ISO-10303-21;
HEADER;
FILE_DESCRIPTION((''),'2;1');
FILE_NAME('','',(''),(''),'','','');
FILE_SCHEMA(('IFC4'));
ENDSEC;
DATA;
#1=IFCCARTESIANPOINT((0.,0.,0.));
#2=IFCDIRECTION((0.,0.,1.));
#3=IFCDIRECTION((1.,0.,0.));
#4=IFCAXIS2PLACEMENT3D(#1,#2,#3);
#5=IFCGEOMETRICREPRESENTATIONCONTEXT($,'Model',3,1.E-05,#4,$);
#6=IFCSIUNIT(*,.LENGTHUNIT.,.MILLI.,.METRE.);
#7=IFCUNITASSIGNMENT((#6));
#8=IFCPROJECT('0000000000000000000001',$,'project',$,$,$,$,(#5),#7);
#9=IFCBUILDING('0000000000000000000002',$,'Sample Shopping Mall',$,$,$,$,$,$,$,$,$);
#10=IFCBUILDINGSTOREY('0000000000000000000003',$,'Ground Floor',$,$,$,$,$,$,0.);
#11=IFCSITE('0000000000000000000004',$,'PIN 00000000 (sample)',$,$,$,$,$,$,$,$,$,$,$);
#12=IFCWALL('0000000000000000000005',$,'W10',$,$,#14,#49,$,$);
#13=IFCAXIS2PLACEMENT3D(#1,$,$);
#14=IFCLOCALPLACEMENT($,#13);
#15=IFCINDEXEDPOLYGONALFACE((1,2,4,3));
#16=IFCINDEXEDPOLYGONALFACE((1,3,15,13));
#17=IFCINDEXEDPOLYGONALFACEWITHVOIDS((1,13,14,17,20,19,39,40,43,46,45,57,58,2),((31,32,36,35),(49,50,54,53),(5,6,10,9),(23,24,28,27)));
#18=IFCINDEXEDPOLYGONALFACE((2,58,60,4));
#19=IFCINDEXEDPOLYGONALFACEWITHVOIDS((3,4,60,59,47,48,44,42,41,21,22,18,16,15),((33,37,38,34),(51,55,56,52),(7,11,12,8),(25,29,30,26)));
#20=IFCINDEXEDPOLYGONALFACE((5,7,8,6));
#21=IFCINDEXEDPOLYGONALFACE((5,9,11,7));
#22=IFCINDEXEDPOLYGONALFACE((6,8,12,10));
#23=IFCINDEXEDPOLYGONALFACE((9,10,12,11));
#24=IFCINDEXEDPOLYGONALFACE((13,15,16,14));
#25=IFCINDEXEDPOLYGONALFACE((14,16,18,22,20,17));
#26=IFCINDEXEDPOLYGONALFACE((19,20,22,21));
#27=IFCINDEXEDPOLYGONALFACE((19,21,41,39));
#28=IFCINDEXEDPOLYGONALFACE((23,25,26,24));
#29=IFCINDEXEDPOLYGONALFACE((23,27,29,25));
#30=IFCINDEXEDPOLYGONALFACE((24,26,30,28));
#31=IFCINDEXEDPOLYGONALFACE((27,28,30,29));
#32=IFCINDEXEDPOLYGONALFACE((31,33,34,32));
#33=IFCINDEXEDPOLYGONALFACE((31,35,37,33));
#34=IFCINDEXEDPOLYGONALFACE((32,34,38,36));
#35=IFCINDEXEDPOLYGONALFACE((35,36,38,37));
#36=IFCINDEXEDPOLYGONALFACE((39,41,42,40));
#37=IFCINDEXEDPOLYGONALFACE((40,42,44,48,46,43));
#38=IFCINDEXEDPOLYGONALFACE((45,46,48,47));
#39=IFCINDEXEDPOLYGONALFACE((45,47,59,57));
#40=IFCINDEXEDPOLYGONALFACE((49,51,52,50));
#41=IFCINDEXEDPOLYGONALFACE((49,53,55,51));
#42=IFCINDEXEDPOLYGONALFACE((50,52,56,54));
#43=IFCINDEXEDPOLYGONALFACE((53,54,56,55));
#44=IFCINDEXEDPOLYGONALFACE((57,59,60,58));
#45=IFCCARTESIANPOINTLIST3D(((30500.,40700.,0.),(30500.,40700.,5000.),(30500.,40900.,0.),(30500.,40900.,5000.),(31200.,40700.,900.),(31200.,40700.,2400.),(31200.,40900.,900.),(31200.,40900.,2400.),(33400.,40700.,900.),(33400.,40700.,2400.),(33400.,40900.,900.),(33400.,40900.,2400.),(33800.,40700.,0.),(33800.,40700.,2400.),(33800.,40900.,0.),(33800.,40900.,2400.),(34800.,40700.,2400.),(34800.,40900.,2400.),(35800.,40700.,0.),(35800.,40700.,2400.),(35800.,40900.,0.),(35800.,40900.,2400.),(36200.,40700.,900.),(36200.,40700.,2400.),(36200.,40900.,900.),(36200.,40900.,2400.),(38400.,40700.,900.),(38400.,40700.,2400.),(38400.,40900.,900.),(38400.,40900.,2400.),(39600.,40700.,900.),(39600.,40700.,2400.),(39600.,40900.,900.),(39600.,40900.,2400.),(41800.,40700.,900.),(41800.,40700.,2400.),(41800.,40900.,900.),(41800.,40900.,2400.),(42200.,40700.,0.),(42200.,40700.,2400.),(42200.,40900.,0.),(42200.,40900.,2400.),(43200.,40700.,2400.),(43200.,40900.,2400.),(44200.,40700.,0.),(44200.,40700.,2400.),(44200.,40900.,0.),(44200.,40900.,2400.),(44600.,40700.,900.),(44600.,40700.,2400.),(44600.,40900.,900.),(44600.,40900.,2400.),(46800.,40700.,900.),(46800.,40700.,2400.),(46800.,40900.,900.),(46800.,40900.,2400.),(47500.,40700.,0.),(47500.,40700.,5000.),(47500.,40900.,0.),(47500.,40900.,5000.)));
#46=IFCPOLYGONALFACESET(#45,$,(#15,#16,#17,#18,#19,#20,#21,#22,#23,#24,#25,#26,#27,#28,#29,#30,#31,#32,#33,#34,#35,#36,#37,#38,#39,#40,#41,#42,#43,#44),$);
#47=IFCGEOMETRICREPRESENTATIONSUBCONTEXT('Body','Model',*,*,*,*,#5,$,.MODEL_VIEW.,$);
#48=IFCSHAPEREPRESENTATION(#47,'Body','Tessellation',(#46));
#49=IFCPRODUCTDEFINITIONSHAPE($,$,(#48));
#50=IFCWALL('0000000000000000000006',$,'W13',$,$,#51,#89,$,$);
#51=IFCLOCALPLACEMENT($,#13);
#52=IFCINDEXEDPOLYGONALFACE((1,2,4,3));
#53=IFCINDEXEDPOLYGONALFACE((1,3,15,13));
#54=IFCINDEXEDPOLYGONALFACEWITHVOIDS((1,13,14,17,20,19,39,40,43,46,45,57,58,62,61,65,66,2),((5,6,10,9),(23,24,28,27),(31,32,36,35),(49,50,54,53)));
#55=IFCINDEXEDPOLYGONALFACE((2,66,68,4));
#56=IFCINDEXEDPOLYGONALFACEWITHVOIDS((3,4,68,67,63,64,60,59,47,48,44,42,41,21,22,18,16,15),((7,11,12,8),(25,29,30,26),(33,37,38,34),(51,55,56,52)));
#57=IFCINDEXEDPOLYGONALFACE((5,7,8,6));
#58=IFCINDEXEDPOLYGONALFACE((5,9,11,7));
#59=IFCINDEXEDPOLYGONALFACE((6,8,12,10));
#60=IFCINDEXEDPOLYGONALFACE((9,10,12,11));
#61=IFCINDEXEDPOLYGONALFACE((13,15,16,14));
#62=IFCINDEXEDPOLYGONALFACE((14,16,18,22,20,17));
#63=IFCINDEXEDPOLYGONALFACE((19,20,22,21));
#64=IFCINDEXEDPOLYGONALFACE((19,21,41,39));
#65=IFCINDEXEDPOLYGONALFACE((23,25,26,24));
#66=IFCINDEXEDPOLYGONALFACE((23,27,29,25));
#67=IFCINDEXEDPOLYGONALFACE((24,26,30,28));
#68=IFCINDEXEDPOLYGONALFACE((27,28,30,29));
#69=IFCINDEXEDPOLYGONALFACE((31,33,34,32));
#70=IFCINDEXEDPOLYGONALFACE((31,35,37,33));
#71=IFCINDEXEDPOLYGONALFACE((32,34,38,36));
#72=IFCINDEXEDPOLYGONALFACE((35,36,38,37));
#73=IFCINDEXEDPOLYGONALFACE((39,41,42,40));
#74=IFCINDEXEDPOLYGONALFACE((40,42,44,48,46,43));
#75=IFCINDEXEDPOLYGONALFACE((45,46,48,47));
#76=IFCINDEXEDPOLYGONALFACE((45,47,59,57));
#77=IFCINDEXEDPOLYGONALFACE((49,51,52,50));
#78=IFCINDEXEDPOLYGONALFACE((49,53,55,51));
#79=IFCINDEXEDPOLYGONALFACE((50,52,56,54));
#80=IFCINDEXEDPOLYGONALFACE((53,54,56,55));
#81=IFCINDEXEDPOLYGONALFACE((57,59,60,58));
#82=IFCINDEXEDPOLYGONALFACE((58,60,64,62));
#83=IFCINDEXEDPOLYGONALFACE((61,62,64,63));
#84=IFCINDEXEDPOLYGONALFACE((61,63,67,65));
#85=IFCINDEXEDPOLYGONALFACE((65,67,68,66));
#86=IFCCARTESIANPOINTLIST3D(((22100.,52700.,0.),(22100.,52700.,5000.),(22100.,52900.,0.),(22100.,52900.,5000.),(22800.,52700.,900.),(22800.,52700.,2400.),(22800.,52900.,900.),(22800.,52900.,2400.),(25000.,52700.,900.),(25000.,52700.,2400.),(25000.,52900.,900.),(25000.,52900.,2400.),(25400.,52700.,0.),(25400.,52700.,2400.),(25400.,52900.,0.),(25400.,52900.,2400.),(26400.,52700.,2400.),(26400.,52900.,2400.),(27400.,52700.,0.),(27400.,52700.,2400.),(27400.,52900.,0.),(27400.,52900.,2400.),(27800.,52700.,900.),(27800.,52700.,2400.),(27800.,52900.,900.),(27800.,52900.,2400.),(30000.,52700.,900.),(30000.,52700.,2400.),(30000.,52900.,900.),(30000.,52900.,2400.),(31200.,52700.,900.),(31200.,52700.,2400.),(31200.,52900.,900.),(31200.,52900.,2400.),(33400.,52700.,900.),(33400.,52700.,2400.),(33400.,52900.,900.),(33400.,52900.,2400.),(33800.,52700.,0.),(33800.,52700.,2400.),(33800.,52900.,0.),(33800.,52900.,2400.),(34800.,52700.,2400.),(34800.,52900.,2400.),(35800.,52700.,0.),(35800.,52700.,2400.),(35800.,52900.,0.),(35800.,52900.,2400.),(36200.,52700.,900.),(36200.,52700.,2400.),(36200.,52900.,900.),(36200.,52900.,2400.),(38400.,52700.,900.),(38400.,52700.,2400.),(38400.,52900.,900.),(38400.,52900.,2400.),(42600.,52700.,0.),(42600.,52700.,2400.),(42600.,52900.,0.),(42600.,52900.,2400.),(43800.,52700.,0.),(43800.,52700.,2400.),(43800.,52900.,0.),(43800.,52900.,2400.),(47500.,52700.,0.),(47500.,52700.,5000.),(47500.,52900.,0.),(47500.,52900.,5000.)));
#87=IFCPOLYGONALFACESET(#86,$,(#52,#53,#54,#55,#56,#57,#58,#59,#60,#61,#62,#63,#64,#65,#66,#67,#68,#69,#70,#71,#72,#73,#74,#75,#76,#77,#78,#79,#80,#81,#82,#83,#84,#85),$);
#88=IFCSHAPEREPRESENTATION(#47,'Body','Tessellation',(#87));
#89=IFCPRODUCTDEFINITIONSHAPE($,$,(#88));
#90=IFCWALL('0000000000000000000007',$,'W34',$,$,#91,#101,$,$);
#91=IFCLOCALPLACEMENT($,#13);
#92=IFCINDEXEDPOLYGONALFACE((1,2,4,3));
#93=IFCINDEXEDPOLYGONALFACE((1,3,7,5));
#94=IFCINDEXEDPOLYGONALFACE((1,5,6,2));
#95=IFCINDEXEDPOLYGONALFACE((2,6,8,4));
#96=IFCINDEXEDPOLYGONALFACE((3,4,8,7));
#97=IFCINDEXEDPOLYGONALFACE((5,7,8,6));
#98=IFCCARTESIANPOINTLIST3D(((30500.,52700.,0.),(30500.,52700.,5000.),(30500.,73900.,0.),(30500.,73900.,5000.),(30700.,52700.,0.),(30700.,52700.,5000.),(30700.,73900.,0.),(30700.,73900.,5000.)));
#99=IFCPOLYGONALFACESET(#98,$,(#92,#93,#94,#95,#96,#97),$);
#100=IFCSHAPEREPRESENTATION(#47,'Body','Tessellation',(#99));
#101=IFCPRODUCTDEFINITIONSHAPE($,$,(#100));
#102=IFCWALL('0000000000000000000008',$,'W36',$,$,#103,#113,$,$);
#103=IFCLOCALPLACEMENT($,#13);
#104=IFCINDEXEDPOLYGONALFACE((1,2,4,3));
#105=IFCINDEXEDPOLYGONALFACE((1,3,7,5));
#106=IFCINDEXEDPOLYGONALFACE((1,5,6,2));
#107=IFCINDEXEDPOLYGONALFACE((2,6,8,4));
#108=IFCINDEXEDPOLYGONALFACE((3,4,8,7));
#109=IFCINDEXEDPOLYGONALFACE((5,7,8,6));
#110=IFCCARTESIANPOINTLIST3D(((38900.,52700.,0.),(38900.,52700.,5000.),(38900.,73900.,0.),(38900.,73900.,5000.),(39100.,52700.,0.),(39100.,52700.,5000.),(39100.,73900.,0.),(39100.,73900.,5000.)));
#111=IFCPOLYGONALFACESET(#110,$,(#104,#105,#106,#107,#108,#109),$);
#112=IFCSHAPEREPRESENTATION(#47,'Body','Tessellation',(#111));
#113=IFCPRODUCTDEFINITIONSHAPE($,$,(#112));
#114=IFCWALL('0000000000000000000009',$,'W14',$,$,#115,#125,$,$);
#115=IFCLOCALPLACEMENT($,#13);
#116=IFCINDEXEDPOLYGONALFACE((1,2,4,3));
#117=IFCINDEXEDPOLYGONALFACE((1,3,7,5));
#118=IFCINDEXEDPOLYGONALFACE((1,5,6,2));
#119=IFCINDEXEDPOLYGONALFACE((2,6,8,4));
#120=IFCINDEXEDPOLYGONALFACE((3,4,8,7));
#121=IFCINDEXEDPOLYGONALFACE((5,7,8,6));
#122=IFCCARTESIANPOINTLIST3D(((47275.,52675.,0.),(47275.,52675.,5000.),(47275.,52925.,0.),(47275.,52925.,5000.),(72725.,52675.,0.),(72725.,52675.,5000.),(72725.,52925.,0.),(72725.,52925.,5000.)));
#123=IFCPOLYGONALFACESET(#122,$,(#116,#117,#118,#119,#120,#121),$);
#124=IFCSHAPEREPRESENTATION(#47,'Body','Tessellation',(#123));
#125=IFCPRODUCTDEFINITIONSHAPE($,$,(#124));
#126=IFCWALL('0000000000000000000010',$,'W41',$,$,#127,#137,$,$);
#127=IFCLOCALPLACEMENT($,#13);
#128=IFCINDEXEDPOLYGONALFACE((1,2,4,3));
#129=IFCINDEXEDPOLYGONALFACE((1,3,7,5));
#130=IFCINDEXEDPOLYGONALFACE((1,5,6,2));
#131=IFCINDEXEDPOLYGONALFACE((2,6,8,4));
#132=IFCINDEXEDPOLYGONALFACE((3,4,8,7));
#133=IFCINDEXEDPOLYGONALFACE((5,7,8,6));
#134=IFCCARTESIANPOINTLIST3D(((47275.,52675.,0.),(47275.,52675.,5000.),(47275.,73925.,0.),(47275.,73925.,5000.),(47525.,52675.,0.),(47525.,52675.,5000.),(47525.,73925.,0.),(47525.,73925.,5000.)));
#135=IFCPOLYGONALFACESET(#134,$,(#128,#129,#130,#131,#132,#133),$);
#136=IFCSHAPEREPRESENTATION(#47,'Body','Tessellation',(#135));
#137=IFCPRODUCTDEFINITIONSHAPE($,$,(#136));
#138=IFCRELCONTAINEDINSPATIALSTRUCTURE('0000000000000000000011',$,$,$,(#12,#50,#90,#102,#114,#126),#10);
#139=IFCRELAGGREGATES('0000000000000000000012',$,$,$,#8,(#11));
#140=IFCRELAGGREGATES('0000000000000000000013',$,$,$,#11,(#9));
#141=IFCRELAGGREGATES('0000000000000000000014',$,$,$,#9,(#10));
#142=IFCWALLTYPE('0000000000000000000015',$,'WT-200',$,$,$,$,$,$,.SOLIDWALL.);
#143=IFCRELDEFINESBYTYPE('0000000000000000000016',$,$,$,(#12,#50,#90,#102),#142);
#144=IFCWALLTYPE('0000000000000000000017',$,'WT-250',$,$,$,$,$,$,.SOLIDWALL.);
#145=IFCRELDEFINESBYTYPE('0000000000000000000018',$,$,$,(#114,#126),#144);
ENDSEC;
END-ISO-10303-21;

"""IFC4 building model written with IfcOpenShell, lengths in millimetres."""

from ifc_helpers import new_model, si_unit, frame, origin_with_axes, place, context, subcontext, project, spatial, indexed_curve, outline, extrude, type_object, element, save


model = new_model("IFC4")

# Units and contexts
model_context = context("Model", 3, precision=1e-05, world=origin_with_axes())
body_context = subcontext(model_context, "Body", "Model", "MODEL_VIEW")
ifc_project = project(units=[si_unit("LENGTHUNIT", "METRE", prefix="MILLI")], contexts=[model_context])

# Site, building, storey
site = spatial("IfcSite", under=ifc_project, Name="PIN 00000000 (sample)")
building = spatial("IfcBuilding", under=site, Name="Sample Shopping Mall")
storey = spatial("IfcBuildingStorey", under=building, Name="Ground Floor", Elevation=0.0)

# Walls, openings
wall_type_1 = type_object("IfcWallType", Name="WT-200", PredefinedType="SOLIDWALL")
wall_1_placement = place(None, frame((30500.0, 40700.0, 0.0), z_axis=(0.0, 0.0, 1.0), x_axis=(1.0, 0.0, 0.0)))
wall_1 = element("IfcWall", 1, at=wall_1_placement, inside=storey, type_object=wall_type_1, Name="W10", context=body_context, shape_type="SweptSolid", body=[
    extrude(outline(indexed_curve([(0.0, 0.0), (0.0, 200.0), (17000.0, 200.0), (17000.0, 0.0), (0.0, 0.0)], self_intersect=False)), origin_with_axes(), (0.0, 0.0, 1.0), 5000.0),
])
opening_1_placement = place(wall_1_placement, frame((3300.0, -100.0, 0.0), z_axis=(0.0, 0.0, 1.0), x_axis=(1.0, 0.0, 0.0)))
element("IfcOpeningElement", 2, at=opening_1_placement, cuts=wall_1, context=body_context, shape_type="SweptSolid", body=[
    extrude(outline(indexed_curve([(0.0, 0.0), (0.0, 400.0), (1000.0, 400.0), (1000.0, 0.0), (0.0, 0.0)], self_intersect=False)), origin_with_axes(), (0.0, 0.0, 1.0), 2400.0),
])
opening_2_placement = place(wall_1_placement, frame((4300.0, -100.0, 0.0), z_axis=(0.0, 0.0, 1.0), x_axis=(1.0, 0.0, 0.0)))
element("IfcOpeningElement", 3, at=opening_2_placement, cuts=wall_1, context=body_context, shape_type="SweptSolid", body=[
    extrude(outline(indexed_curve([(0.0, 0.0), (0.0, 400.0), (1000.0, 400.0), (1000.0, 0.0), (0.0, 0.0)], self_intersect=False)), origin_with_axes(), (0.0, 0.0, 1.0), 2400.0),
])
opening_3_placement = place(wall_1_placement, frame((11700.0, -100.0, 0.0), z_axis=(0.0, 0.0, 1.0), x_axis=(1.0, 0.0, 0.0)))
element("IfcOpeningElement", 4, at=opening_3_placement, cuts=wall_1, context=body_context, shape_type="SweptSolid", body=[
    extrude(outline(indexed_curve([(0.0, 0.0), (0.0, 400.0), (1000.0, 400.0), (1000.0, 0.0), (0.0, 0.0)], self_intersect=False)), origin_with_axes(), (0.0, 0.0, 1.0), 2400.0),
])
opening_4_placement = place(wall_1_placement, frame((12700.0, -100.0, 0.0), z_axis=(0.0, 0.0, 1.0), x_axis=(1.0, 0.0, 0.0)))
element("IfcOpeningElement", 5, at=opening_4_placement, cuts=wall_1, context=body_context, shape_type="SweptSolid", body=[
    extrude(outline(indexed_curve([(0.0, 0.0), (0.0, 400.0), (1000.0, 400.0), (1000.0, 0.0), (0.0, 0.0)], self_intersect=False)), origin_with_axes(), (0.0, 0.0, 1.0), 2400.0),
])
opening_5_placement = place(wall_1_placement, frame((700.0, -100.0, 900.0), z_axis=(0.0, 0.0, 1.0), x_axis=(1.0, 0.0, 0.0)))
element("IfcOpeningElement", 6, at=opening_5_placement, cuts=wall_1, context=body_context, shape_type="SweptSolid", body=[
    extrude(outline(indexed_curve([(0.0, 0.0), (0.0, 400.0), (2200.0, 400.0), (2200.0, 0.0), (0.0, 0.0)], self_intersect=False)), origin_with_axes(), (0.0, 0.0, 1.0), 1500.0),
])
opening_6_placement = place(wall_1_placement, frame((5700.0, -100.0, 900.0), z_axis=(0.0, 0.0, 1.0), x_axis=(1.0, 0.0, 0.0)))
element("IfcOpeningElement", 7, at=opening_6_placement, cuts=wall_1, context=body_context, shape_type="SweptSolid", body=[
    extrude(outline(indexed_curve([(0.0, 0.0), (0.0, 400.0), (2200.0, 400.0), (2200.0, 0.0), (0.0, 0.0)], self_intersect=False)), origin_with_axes(), (0.0, 0.0, 1.0), 1500.0),
])
opening_7_placement = place(wall_1_placement, frame((9100.0, -100.0, 900.0), z_axis=(0.0, 0.0, 1.0), x_axis=(1.0, 0.0, 0.0)))
element("IfcOpeningElement", 8, at=opening_7_placement, cuts=wall_1, context=body_context, shape_type="SweptSolid", body=[
    extrude(outline(indexed_curve([(0.0, 0.0), (0.0, 400.0), (2200.0, 400.0), (2200.0, 0.0), (0.0, 0.0)], self_intersect=False)), origin_with_axes(), (0.0, 0.0, 1.0), 1500.0),
])
opening_8_placement = place(wall_1_placement, frame((14100.0, -100.0, 900.0), z_axis=(0.0, 0.0, 1.0), x_axis=(1.0, 0.0, 0.0)))
element("IfcOpeningElement", 9, at=opening_8_placement, cuts=wall_1, context=body_context, shape_type="SweptSolid", body=[
    extrude(outline(indexed_curve([(0.0, 0.0), (0.0, 400.0), (2200.0, 400.0), (2200.0, 0.0), (0.0, 0.0)], self_intersect=False)), origin_with_axes(), (0.0, 0.0, 1.0), 1500.0),
])
wall_2_placement = place(None, frame((22100.0, 52700.0, 0.0), z_axis=(0.0, 0.0, 1.0), x_axis=(1.0, 0.0, 0.0)))
wall_2 = element("IfcWall", 10, at=wall_2_placement, inside=storey, type_object=wall_type_1, Name="W13", context=body_context, shape_type="SweptSolid", body=[
    extrude(outline(indexed_curve([(0.0, 0.0), (0.0, 200.0), (25400.0, 200.0), (25400.0, 0.0), (0.0, 0.0)], self_intersect=False)), origin_with_axes(), (0.0, 0.0, 1.0), 5000.0),
])
opening_9_placement = place(wall_2_placement, frame((3300.0, -100.0, 0.0), z_axis=(0.0, 0.0, 1.0), x_axis=(1.0, 0.0, 0.0)))
element("IfcOpeningElement", 11, at=opening_9_placement, cuts=wall_2, context=body_context, shape_type="SweptSolid", body=[
    extrude(outline(indexed_curve([(0.0, 0.0), (0.0, 400.0), (1000.0, 400.0), (1000.0, 0.0), (0.0, 0.0)], self_intersect=False)), origin_with_axes(), (0.0, 0.0, 1.0), 2400.0),
])
opening_10_placement = place(wall_2_placement, frame((4300.0, -100.0, 0.0), z_axis=(0.0, 0.0, 1.0), x_axis=(1.0, 0.0, 0.0)))
element("IfcOpeningElement", 12, at=opening_10_placement, cuts=wall_2, context=body_context, shape_type="SweptSolid", body=[
    extrude(outline(indexed_curve([(0.0, 0.0), (0.0, 400.0), (1000.0, 400.0), (1000.0, 0.0), (0.0, 0.0)], self_intersect=False)), origin_with_axes(), (0.0, 0.0, 1.0), 2400.0),
])
opening_11_placement = place(wall_2_placement, frame((11700.0, -100.0, 0.0), z_axis=(0.0, 0.0, 1.0), x_axis=(1.0, 0.0, 0.0)))
element("IfcOpeningElement", 13, at=opening_11_placement, cuts=wall_2, context=body_context, shape_type="SweptSolid", body=[
    extrude(outline(indexed_curve([(0.0, 0.0), (0.0, 400.0), (1000.0, 400.0), (1000.0, 0.0), (0.0, 0.0)], self_intersect=False)), origin_with_axes(), (0.0, 0.0, 1.0), 2400.0),
])
opening_12_placement = place(wall_2_placement, frame((12700.0, -100.0, 0.0), z_axis=(0.0, 0.0, 1.0), x_axis=(1.0, 0.0, 0.0)))
element("IfcOpeningElement", 14, at=opening_12_placement, cuts=wall_2, context=body_context, shape_type="SweptSolid", body=[
    extrude(outline(indexed_curve([(0.0, 0.0), (0.0, 400.0), (1000.0, 400.0), (1000.0, 0.0), (0.0, 0.0)], self_intersect=False)), origin_with_axes(), (0.0, 0.0, 1.0), 2400.0),
])
opening_13_placement = place(wall_2_placement, frame((20500.0, -100.0, 0.0), z_axis=(0.0, 0.0, 1.0), x_axis=(1.0, 0.0, 0.0)))
element("IfcOpeningElement", 15, at=opening_13_placement, cuts=wall_2, context=body_context, shape_type="SweptSolid", body=[
    extrude(outline(indexed_curve([(0.0, 0.0), (0.0, 400.0), (1200.0, 400.0), (1200.0, 0.0), (0.0, 0.0)], self_intersect=False)), origin_with_axes(), (0.0, 0.0, 1.0), 2400.0),
])
opening_14_placement = place(wall_2_placement, frame((700.0, -100.0, 900.0), z_axis=(0.0, 0.0, 1.0), x_axis=(1.0, 0.0, 0.0)))
element("IfcOpeningElement", 16, at=opening_14_placement, cuts=wall_2, context=body_context, shape_type="SweptSolid", body=[
    extrude(outline(indexed_curve([(0.0, 0.0), (0.0, 400.0), (2200.0, 400.0), (2200.0, 0.0), (0.0, 0.0)], self_intersect=False)), origin_with_axes(), (0.0, 0.0, 1.0), 1500.0),
])
opening_15_placement = place(wall_2_placement, frame((5700.0, -100.0, 900.0), z_axis=(0.0, 0.0, 1.0), x_axis=(1.0, 0.0, 0.0)))
element("IfcOpeningElement", 17, at=opening_15_placement, cuts=wall_2, context=body_context, shape_type="SweptSolid", body=[
    extrude(outline(indexed_curve([(0.0, 0.0), (0.0, 400.0), (2200.0, 400.0), (2200.0, 0.0), (0.0, 0.0)], self_intersect=False)), origin_with_axes(), (0.0, 0.0, 1.0), 1500.0),
])
opening_16_placement = place(wall_2_placement, frame((9100.0, -100.0, 900.0), z_axis=(0.0, 0.0, 1.0), x_axis=(1.0, 0.0, 0.0)))
element("IfcOpeningElement", 18, at=opening_16_placement, cuts=wall_2, context=body_context, shape_type="SweptSolid", body=[
    extrude(outline(indexed_curve([(0.0, 0.0), (0.0, 400.0), (2200.0, 400.0), (2200.0, 0.0), (0.0, 0.0)], self_intersect=False)), origin_with_axes(), (0.0, 0.0, 1.0), 1500.0),
])
opening_17_placement = place(wall_2_placement, frame((14100.0, -100.0, 900.0), z_axis=(0.0, 0.0, 1.0), x_axis=(1.0, 0.0, 0.0)))
element("IfcOpeningElement", 19, at=opening_17_placement, cuts=wall_2, context=body_context, shape_type="SweptSolid", body=[
    extrude(outline(indexed_curve([(0.0, 0.0), (0.0, 400.0), (2200.0, 400.0), (2200.0, 0.0), (0.0, 0.0)], self_intersect=False)), origin_with_axes(), (0.0, 0.0, 1.0), 1500.0),
])

# Walls
for number, where, z_axis, x_axis, name in (
    (20, (30700.0, 52700.0, 0.0), (0.0, 0.0, 1.0), (0.0, 1.0, 0.0), "W34"),
    (21, (39100.0, 52700.0, 0.0), (0.0, 0.0, 1.0), (0.0, 1.0, 0.0), "W36"),
):
    element("IfcWall", number, at=place(None, frame(where, z_axis=z_axis, x_axis=x_axis)), inside=storey, type_object=wall_type_1, Name=name, context=body_context, shape_type="SweptSolid", body=[
        extrude(outline(indexed_curve([(0.0, 0.0), (0.0, 200.0), (21200.0, 200.0), (21200.0, 0.0), (0.0, 0.0)], self_intersect=False)), origin_with_axes(), (0.0, 0.0, 1.0), 5000.0),
    ])

# Shared definitions
wall_type_2 = type_object("IfcWallType", Name="WT-250", PredefinedType="SOLIDWALL")

# Walls
wall_3_placement = place(None, frame((47275.0, 52675.0, 0.0), z_axis=(0.0, 0.0, 1.0), x_axis=(1.0, 0.0, 0.0)))
element("IfcWall", 22, at=wall_3_placement, inside=storey, type_object=wall_type_2, Name="W14", context=body_context, shape_type="SweptSolid", body=[
    extrude(outline(indexed_curve([(0.0, 0.0), (0.0, 250.0), (25450.0, 250.0), (25450.0, 0.0), (0.0, 0.0)], self_intersect=False)), origin_with_axes(), (0.0, 0.0, 1.0), 5000.0),
])
wall_4_placement = place(None, frame((47525.0, 52675.0, 0.0), z_axis=(0.0, 0.0, 1.0), x_axis=(0.0, 1.0, 0.0)))
element("IfcWall", 23, at=wall_4_placement, inside=storey, type_object=wall_type_2, Name="W41", context=body_context, shape_type="SweptSolid", body=[
    extrude(outline(indexed_curve([(0.0, 0.0), (0.0, 250.0), (21250.0, 250.0), (21250.0, 0.0), (0.0, 0.0)], self_intersect=False)), origin_with_axes(), (0.0, 0.0, 1.0), 5000.0),
])

save(model, "model.ifc")
